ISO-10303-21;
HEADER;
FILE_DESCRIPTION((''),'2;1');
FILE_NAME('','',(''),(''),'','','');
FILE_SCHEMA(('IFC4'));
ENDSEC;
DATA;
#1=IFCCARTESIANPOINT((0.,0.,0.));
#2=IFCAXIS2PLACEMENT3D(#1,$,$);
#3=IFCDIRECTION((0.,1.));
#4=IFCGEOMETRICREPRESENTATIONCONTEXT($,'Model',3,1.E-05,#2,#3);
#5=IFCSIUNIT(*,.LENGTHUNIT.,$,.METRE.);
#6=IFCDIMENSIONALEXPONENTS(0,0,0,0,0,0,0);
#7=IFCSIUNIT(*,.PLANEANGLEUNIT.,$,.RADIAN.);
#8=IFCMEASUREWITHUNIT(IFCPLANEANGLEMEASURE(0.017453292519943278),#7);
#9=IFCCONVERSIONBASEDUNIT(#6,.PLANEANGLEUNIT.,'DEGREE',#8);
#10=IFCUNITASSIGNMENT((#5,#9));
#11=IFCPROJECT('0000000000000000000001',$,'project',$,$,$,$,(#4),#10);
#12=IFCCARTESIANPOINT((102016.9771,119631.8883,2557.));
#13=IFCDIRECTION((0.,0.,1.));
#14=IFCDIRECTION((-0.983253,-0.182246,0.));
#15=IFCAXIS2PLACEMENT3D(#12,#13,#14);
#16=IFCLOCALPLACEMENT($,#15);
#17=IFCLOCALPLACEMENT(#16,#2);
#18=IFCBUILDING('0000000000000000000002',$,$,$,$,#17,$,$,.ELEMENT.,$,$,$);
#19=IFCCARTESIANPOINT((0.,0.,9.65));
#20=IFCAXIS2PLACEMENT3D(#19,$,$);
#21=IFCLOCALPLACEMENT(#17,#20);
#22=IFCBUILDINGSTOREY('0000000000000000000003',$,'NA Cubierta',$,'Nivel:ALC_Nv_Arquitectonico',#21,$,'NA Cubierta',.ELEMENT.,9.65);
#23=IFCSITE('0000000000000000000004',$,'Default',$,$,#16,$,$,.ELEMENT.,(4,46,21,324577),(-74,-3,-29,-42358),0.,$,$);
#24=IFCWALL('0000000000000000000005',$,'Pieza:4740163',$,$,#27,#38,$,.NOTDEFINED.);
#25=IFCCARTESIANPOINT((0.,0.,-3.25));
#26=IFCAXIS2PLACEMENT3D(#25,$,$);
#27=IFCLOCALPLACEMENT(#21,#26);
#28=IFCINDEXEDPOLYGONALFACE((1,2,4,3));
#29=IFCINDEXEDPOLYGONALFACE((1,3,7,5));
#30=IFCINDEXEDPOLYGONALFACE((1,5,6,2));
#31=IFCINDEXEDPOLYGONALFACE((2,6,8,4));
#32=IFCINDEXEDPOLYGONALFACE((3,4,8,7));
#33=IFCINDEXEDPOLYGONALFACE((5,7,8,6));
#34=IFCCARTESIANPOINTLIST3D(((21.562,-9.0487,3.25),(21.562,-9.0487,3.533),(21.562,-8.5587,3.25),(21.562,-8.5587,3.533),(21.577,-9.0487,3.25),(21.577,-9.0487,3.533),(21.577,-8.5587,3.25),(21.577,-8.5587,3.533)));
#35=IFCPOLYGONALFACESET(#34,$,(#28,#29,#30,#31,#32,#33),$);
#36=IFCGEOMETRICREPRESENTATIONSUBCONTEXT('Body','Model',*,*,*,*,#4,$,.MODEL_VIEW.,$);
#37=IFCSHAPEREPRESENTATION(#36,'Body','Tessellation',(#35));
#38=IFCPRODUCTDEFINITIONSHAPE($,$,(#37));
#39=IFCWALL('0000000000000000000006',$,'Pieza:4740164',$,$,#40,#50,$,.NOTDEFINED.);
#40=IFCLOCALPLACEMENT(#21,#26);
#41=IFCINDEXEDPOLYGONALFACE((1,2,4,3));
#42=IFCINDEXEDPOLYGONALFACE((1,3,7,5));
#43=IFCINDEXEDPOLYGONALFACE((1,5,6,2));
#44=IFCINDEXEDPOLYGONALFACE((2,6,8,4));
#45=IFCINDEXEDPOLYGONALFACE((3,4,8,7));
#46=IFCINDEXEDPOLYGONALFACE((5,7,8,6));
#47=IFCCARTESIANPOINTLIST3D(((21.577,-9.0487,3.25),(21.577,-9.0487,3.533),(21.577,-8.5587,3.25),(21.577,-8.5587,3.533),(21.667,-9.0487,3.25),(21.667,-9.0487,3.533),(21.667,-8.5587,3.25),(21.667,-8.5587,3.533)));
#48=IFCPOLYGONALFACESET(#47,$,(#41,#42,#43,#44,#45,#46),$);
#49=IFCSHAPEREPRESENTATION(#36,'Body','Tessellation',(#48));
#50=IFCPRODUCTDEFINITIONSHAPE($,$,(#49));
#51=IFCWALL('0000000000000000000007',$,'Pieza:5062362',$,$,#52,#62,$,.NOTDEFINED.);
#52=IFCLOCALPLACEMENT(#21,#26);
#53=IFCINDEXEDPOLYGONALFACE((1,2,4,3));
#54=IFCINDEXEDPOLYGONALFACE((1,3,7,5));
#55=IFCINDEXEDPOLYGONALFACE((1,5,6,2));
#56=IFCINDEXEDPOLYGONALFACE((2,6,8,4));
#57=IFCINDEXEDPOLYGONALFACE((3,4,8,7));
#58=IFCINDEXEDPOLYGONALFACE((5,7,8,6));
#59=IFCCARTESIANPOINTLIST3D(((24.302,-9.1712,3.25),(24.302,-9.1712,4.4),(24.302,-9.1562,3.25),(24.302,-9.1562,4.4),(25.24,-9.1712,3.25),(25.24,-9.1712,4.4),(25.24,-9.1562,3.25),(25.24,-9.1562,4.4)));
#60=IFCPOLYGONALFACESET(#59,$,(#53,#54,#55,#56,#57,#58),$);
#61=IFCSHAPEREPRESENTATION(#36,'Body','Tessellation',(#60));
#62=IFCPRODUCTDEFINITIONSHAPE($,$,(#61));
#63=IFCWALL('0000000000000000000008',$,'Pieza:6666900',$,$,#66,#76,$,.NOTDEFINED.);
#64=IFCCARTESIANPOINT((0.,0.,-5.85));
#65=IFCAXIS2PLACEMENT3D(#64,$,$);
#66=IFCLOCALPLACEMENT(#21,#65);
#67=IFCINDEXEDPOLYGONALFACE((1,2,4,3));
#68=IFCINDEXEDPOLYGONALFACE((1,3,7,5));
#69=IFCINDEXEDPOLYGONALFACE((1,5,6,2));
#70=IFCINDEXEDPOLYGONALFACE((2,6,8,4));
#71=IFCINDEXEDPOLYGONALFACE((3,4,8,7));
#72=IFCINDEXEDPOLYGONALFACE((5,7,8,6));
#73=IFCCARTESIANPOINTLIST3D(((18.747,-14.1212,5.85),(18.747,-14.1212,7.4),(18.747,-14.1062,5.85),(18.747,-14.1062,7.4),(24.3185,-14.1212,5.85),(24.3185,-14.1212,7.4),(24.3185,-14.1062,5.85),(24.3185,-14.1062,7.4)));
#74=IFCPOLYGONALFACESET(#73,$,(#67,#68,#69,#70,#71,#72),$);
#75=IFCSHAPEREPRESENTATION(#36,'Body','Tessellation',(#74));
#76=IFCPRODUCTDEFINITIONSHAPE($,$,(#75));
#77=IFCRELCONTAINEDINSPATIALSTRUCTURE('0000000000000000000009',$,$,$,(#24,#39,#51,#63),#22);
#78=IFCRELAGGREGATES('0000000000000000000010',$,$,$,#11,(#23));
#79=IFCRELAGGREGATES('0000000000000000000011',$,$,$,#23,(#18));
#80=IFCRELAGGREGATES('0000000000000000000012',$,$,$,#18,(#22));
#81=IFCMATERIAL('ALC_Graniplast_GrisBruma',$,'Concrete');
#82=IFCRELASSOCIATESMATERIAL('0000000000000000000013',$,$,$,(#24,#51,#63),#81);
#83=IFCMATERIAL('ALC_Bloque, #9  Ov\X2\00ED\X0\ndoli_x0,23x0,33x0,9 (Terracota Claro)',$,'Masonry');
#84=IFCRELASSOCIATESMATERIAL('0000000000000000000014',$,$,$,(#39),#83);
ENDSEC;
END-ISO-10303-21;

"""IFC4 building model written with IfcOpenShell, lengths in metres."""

from ifc_helpers import new_model, entity, si_unit, converted_unit, direction, frame, frame_2d, origin, place, context, subcontext, project, spatial, rectangle, extrude, material, element, save


model = new_model("IFC4")

# Units and contexts
model_context = context("Model", 3, precision=1e-05, world=origin(), true_north=direction((0.0, 1.0)))
body_context = subcontext(model_context, "Body", "Model", "MODEL_VIEW")
ifc_project = project(units=[si_unit("LENGTHUNIT", "METRE"), converted_unit("PLANEANGLEUNIT", "DEGREE", entity("IfcPlaneAngleMeasure", 0.017453292519943278), si_unit("PLANEANGLEUNIT", "RADIAN"), dimensions=[0, 0, 0, 0, 0, 0, 0])], contexts=[model_context])

# Site, building, storey
site_placement = place(None, frame((102016.9771, 119631.8883, 2557.0), z_axis=(0.0, 0.0, 1.0), x_axis=(-0.983253, -0.182246, 0.0)))
site = spatial("IfcSite", under=ifc_project, at=site_placement, Name="Default", CompositionType="ELEMENT", RefLatitude=(4, 46, 21, 324577), RefLongitude=(-74, -3, -29, -42358), RefElevation=0.0)
building_placement = place(site_placement, origin())
building = spatial("IfcBuilding", under=site, at=building_placement, CompositionType="ELEMENT")
storey_placement = place(building_placement, frame((0.0, 0.0, 9.65)))
storey = spatial("IfcBuildingStorey", under=building, at=storey_placement, Name="NA Cubierta", ObjectType="Nivel:ALC_Nv_Arquitectonico", LongName="NA Cubierta", CompositionType="ELEMENT", Elevation=9.65)

# Walls
ifc_material_1 = material(Name="ALC_Bloque, #9  Ovíndoli_x0,23x0,33x0,9 (Terracota Claro)", Category="Masonry")
ifc_material_2 = material(Name="ALC_Graniplast_GrisBruma", Category="Concrete")
wall_1_placement = place(storey_placement, frame((0.0, 0.0, -3.25)))
element("IfcWall", 1, at=wall_1_placement, inside=storey, material=ifc_material_2, Name="Pieza:4740163", PredefinedType="NOTDEFINED", context=body_context, shape_type="SweptSolid", body=[
    extrude(rectangle(XDim=0.49, YDim=0.015, at=frame_2d((0.0, 0.0), x_axis=(1.0, 0.0))), frame((21.5695, -8.8037, 3.25), z_axis=(0.0, 0.0, 1.0), x_axis=(0.0, -1.0, 0.0)), (0.0, 0.0, 1.0), 0.283),
])
wall_2_placement = place(storey_placement, frame((0.0, 0.0, -3.25)))
element("IfcWall", 2, at=wall_2_placement, inside=storey, material=ifc_material_1, Name="Pieza:4740164", PredefinedType="NOTDEFINED", context=body_context, shape_type="SweptSolid", body=[
    extrude(rectangle(XDim=0.49, YDim=0.09, at=frame_2d((0.0, 0.0), x_axis=(1.0, 0.0))), frame((21.622, -8.8037, 3.25), z_axis=(0.0, 0.0, 1.0), x_axis=(0.0, -1.0, 0.0)), (0.0, 0.0, 1.0), 0.283),
])
wall_3_placement = place(storey_placement, frame((0.0, 0.0, -3.25)))
element("IfcWall", 3, at=wall_3_placement, inside=storey, material=ifc_material_2, Name="Pieza:5062362", PredefinedType="NOTDEFINED", context=body_context, shape_type="SweptSolid", body=[
    extrude(rectangle(XDim=0.015, YDim=0.938, at=frame_2d((0.0, 0.0), x_axis=(1.0, 0.0))), frame((24.771, -9.1637, 3.25), z_axis=(0.0, 0.0, 1.0), x_axis=(0.0, -1.0, 0.0)), (0.0, 0.0, 1.0), 1.15),
])

# Wall
wall_4_placement = place(storey_placement, frame((0.0, 0.0, -5.85)))
element("IfcWall", 4, at=wall_4_placement, inside=storey, material=ifc_material_2, Name="Pieza:6666900", PredefinedType="NOTDEFINED", context=body_context, shape_type="SweptSolid", body=[
    extrude(rectangle(XDim=0.015, YDim=5.5715, at=frame_2d((0.0, 0.0), x_axis=(1.0, 0.0))), frame((21.5328, -14.1137, 5.85), z_axis=(0.0, 0.0, 1.0), x_axis=(0.0, -1.0, 0.0)), (0.0, 0.0, 1.0), 1.55),
])

save(model, "model.ifc")
